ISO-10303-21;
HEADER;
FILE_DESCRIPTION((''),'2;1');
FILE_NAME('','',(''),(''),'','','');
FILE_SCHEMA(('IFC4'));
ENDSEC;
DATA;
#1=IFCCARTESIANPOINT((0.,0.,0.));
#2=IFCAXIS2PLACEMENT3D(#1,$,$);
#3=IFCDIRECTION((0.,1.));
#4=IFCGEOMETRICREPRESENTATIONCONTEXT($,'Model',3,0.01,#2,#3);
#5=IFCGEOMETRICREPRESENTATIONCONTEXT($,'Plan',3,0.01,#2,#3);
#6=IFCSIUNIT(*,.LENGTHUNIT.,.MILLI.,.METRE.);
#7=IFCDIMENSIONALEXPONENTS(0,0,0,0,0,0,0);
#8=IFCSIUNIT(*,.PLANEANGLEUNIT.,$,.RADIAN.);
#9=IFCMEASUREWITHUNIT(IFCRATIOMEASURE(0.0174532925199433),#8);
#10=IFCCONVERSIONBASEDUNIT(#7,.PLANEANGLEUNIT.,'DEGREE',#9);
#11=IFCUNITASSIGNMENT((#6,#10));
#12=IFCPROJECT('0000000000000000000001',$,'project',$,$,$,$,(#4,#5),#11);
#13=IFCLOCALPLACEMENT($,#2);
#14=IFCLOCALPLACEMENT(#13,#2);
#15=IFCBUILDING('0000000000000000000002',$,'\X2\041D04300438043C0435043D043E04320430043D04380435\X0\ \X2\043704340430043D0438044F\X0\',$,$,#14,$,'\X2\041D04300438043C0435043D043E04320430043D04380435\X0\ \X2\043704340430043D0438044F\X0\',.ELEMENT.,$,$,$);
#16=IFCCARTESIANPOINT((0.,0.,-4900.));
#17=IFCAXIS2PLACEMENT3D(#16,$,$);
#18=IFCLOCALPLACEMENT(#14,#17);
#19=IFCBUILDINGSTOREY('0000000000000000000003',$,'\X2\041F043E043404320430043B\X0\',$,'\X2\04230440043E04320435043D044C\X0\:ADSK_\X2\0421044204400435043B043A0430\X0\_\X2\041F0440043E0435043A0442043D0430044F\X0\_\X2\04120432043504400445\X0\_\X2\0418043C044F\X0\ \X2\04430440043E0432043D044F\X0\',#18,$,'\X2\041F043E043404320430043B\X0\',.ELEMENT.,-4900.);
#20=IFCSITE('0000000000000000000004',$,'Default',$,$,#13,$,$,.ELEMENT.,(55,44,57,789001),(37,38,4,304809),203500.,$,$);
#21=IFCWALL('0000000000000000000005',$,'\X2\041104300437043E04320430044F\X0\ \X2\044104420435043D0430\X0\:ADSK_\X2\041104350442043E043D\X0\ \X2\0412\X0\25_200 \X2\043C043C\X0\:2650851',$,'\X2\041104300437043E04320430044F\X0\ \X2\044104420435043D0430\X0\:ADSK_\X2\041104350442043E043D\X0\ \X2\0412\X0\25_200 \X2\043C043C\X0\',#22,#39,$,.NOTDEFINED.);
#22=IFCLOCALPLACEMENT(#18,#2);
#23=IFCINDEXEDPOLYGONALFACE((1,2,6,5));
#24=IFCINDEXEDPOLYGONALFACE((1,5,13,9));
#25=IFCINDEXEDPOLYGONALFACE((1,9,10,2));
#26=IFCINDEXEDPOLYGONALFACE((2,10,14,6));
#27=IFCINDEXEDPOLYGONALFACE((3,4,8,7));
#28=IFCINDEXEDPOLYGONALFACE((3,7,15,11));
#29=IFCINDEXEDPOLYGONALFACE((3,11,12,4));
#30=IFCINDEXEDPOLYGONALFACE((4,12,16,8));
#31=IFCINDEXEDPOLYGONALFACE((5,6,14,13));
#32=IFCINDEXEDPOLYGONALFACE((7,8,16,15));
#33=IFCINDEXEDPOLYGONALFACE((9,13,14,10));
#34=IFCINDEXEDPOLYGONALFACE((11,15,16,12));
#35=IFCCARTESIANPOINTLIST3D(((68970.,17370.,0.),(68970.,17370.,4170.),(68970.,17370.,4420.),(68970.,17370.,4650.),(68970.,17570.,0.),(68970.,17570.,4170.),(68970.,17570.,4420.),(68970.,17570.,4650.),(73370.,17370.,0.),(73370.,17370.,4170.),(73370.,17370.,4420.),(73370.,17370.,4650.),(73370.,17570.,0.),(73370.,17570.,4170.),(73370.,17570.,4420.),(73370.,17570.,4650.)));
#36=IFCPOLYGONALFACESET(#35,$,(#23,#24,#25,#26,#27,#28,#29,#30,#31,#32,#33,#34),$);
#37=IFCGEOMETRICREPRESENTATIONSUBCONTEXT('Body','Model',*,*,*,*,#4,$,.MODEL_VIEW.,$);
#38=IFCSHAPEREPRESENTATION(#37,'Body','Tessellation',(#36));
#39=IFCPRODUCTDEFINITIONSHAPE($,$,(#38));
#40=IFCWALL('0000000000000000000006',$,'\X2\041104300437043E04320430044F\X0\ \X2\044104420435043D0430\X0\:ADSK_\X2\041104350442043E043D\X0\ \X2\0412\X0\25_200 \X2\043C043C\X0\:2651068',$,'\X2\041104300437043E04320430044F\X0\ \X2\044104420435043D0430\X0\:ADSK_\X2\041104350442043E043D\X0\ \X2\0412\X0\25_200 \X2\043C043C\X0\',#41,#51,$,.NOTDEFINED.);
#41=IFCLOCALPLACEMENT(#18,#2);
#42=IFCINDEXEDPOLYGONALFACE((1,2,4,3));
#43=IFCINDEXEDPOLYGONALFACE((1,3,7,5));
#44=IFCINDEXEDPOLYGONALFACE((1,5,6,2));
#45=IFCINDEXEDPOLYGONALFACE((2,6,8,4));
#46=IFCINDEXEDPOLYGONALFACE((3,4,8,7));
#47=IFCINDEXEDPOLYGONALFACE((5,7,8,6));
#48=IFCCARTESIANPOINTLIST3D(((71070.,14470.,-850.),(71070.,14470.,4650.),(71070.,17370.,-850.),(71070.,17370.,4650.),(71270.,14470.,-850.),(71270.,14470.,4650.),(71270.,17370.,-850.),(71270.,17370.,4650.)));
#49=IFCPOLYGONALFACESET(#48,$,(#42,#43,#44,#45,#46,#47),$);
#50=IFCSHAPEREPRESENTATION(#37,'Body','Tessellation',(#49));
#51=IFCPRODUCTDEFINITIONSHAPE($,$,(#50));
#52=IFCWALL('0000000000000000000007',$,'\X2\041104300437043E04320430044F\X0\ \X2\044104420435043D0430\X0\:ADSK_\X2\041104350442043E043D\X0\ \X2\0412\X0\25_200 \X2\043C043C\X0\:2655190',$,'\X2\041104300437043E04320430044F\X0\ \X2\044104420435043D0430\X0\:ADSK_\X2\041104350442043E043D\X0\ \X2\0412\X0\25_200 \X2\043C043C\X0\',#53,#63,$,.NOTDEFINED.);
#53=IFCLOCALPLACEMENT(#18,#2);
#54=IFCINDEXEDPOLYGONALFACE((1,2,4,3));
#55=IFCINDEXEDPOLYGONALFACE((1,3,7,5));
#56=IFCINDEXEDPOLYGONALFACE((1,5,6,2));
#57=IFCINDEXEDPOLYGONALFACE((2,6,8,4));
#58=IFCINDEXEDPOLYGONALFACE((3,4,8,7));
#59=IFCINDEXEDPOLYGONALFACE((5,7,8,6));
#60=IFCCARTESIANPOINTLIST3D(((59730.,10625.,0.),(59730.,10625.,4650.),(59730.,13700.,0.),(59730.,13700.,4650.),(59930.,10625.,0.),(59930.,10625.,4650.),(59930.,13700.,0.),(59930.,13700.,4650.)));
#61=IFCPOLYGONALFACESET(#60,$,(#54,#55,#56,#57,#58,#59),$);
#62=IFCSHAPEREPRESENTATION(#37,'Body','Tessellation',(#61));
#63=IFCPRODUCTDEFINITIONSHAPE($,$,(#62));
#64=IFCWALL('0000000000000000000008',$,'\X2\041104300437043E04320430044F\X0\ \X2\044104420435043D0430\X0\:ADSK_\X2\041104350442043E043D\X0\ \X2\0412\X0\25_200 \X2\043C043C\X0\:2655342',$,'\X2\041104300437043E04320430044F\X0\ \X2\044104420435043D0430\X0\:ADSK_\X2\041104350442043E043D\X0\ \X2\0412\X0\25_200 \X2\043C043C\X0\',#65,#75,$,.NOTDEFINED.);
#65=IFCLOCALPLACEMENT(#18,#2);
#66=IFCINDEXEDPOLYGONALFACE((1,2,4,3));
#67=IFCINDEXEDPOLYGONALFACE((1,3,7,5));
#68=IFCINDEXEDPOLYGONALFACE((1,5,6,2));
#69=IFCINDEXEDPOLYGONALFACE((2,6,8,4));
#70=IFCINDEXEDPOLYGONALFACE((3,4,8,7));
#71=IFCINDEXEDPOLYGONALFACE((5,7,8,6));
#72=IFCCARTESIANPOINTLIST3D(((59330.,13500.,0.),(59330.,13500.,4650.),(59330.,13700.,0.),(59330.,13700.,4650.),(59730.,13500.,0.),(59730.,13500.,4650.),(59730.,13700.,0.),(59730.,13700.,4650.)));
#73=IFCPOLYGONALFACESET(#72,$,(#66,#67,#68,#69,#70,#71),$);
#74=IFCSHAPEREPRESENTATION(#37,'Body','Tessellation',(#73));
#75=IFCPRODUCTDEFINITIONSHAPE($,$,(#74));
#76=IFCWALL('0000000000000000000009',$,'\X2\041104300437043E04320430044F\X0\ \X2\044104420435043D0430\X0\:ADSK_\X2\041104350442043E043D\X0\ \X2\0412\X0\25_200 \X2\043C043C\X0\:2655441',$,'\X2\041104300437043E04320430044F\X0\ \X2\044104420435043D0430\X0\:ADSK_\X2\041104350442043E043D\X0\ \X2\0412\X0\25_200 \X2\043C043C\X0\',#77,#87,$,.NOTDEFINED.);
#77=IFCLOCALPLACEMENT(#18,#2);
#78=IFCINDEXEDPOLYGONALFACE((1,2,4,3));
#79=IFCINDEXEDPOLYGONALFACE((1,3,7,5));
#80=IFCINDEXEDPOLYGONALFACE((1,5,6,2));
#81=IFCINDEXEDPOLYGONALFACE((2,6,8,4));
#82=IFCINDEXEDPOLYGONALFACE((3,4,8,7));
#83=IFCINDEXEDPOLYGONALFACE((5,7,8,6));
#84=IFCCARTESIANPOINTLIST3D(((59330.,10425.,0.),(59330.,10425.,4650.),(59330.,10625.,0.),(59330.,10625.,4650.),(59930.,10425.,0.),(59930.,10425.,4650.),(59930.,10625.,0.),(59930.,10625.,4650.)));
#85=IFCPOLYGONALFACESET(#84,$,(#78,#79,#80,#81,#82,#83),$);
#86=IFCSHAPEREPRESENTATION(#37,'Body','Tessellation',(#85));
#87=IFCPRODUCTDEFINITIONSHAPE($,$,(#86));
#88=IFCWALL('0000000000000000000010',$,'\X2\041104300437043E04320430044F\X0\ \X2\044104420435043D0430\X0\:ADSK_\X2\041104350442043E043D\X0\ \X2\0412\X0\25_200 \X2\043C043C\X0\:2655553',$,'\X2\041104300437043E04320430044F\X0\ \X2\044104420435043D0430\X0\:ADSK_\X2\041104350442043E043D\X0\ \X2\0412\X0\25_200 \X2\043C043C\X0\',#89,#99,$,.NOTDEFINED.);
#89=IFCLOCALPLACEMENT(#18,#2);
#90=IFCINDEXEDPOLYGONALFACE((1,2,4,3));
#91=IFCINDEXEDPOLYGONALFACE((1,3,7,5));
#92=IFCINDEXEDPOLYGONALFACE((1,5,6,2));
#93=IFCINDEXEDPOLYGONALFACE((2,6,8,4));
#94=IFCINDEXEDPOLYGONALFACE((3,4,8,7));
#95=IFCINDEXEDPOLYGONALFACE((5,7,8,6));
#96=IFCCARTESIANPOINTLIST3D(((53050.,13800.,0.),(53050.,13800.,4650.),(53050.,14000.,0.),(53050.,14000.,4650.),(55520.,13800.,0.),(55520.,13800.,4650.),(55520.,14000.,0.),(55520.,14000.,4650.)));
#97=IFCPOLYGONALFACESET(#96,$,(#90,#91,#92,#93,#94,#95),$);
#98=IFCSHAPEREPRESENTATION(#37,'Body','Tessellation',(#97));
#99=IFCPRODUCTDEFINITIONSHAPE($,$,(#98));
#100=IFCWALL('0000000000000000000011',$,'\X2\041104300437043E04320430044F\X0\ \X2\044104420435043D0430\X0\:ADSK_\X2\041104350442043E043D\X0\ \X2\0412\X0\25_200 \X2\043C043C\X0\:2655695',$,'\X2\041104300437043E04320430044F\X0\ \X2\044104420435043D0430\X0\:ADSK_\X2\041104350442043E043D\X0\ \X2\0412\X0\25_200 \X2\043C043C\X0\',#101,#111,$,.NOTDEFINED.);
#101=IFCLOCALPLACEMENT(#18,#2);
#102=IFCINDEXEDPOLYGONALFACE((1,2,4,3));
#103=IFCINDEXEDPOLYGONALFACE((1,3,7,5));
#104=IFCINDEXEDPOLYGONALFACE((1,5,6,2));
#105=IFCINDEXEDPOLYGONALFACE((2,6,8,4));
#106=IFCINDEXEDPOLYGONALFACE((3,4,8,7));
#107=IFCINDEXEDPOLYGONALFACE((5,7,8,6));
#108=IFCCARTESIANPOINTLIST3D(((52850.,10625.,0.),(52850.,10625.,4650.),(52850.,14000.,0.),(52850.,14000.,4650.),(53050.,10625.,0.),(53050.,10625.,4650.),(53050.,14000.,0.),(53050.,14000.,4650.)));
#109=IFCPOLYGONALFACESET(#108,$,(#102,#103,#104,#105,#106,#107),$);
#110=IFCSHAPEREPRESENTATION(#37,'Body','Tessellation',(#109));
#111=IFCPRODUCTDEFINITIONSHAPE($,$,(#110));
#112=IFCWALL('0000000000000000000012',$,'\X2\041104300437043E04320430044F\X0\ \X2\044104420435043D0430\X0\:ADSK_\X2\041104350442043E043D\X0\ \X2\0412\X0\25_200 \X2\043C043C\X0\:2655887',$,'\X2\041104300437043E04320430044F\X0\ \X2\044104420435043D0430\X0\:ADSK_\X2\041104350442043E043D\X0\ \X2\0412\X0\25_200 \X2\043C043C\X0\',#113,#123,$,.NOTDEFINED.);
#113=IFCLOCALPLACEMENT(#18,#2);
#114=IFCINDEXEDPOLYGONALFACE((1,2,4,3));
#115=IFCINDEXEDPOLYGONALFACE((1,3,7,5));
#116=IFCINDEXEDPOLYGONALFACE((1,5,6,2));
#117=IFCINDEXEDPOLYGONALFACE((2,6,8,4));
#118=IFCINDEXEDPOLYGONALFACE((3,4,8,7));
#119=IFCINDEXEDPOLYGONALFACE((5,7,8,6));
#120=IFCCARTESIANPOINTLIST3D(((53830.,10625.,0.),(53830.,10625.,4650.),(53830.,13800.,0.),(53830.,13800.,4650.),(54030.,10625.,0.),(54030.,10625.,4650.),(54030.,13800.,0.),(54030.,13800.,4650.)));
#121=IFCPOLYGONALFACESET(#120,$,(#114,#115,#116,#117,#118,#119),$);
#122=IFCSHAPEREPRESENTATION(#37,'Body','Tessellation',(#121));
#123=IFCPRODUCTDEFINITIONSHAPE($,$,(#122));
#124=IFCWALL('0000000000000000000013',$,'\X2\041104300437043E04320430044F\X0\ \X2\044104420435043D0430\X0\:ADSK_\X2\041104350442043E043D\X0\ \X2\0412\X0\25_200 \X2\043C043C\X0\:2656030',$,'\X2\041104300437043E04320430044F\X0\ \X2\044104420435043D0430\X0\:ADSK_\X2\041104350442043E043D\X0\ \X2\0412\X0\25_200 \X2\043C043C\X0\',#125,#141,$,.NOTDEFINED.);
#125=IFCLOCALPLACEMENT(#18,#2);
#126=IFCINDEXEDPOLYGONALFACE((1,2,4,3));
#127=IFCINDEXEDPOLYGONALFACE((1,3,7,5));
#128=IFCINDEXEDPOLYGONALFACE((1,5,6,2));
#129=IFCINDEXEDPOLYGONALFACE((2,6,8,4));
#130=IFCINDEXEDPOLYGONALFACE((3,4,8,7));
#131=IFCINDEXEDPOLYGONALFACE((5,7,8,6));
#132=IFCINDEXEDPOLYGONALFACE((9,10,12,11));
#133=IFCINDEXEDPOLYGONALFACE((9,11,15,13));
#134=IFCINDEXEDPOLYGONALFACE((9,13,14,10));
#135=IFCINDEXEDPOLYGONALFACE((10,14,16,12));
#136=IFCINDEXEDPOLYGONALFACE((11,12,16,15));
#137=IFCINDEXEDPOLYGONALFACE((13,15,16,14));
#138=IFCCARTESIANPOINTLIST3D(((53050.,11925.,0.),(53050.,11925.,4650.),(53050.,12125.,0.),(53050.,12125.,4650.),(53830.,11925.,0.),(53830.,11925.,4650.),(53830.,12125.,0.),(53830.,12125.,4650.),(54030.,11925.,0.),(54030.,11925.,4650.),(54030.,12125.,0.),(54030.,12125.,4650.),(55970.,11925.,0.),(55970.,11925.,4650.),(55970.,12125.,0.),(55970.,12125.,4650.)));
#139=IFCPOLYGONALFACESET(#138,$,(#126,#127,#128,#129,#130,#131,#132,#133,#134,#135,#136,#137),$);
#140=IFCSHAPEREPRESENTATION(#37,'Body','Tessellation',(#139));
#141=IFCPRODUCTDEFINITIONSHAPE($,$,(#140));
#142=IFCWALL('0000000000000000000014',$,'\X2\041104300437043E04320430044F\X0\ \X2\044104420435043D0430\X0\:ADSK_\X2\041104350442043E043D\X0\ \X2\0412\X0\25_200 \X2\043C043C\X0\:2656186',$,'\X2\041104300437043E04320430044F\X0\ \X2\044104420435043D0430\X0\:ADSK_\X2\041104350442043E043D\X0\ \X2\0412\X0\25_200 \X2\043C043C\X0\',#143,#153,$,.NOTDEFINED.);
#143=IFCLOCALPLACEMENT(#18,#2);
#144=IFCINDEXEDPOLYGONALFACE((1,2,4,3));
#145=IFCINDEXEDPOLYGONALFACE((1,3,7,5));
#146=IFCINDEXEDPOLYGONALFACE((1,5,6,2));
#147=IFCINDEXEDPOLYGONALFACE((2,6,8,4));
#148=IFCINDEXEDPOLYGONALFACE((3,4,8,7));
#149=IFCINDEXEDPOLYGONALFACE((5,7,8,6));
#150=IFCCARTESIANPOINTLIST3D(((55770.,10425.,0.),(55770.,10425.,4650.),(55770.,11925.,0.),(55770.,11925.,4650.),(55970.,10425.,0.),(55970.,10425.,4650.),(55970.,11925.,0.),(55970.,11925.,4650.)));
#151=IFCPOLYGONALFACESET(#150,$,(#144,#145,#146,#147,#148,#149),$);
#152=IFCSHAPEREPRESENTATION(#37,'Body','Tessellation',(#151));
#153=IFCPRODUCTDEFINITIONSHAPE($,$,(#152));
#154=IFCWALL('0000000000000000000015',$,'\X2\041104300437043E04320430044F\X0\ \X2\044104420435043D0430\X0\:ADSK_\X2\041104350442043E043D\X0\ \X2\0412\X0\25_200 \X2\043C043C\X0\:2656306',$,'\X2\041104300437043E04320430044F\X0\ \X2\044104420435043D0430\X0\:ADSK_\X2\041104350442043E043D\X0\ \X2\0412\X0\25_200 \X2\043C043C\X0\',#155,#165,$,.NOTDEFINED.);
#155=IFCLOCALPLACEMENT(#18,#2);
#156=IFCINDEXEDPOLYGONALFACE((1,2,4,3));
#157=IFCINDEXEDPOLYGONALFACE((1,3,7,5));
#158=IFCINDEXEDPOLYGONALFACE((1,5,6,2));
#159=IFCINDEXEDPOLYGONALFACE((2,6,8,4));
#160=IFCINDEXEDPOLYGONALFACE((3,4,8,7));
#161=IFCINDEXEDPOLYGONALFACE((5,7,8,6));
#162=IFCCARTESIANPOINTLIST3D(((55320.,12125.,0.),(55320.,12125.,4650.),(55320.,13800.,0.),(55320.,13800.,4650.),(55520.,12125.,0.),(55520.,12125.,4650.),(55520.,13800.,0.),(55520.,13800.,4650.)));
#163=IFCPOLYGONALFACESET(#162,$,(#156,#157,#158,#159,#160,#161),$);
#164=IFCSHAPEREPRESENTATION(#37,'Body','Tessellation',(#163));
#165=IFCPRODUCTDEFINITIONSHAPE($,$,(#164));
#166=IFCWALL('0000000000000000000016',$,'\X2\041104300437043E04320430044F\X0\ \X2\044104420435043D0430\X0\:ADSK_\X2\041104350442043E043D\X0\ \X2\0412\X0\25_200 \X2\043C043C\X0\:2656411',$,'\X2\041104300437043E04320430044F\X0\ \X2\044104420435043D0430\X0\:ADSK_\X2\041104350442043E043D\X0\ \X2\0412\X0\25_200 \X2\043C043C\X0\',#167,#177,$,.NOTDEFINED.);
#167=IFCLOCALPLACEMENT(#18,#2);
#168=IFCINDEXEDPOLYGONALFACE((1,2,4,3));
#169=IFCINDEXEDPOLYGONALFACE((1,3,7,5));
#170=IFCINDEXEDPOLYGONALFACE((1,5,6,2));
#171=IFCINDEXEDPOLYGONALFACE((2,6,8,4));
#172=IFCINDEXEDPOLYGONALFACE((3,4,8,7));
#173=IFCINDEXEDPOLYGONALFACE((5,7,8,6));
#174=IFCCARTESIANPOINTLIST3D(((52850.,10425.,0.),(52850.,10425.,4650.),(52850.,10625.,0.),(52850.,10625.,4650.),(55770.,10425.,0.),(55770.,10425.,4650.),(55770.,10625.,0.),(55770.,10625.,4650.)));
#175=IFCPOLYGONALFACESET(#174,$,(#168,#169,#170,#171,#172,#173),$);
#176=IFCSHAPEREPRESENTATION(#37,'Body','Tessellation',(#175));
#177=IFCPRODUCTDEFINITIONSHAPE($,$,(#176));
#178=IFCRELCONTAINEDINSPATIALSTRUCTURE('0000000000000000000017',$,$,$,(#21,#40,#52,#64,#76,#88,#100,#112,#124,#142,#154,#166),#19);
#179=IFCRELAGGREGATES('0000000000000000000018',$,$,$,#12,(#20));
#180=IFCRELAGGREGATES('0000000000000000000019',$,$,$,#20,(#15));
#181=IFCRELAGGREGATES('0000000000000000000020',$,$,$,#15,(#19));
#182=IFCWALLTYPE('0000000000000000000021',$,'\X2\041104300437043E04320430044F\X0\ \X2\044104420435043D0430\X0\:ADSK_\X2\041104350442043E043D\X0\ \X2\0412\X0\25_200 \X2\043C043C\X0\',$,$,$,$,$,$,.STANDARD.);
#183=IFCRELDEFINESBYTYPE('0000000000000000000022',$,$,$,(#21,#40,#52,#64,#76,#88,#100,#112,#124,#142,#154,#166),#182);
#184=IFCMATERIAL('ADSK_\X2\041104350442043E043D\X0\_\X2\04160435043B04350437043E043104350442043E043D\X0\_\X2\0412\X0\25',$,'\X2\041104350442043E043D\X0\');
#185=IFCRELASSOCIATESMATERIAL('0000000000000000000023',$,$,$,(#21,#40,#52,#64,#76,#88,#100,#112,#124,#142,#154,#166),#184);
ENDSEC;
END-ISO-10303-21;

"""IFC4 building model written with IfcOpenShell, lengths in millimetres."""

from ifc_helpers import new_model, entity, si_unit, converted_unit, direction, frame, origin, place, context, subcontext, project, spatial, indexed_curve, outline, extrude, material, type_object, element, save


model = new_model("IFC4")

# Units and contexts
model_context = context("Model", 3, precision=0.01, world=origin(), true_north=direction((0.0, 1.0)))
plan_context = context("Plan", 3, precision=0.01, world=origin(), true_north=direction((0.0, 1.0)))
body_context = subcontext(model_context, "Body", "Model", "MODEL_VIEW")
ifc_project = project(units=[si_unit("LENGTHUNIT", "METRE", prefix="MILLI"), converted_unit("PLANEANGLEUNIT", "DEGREE", entity("IfcRatioMeasure", 0.0174532925199433), si_unit("PLANEANGLEUNIT", "RADIAN"), dimensions=[0, 0, 0, 0, 0, 0, 0])], contexts=[model_context, plan_context])

# Site, building, storey
site_placement = place(None, origin())
site = spatial("IfcSite", under=ifc_project, at=site_placement, Name="Default", CompositionType="ELEMENT", RefLatitude=(55, 44, 57, 789001), RefLongitude=(37, 38, 4, 304809), RefElevation=203500.0)
building_placement = place(site_placement, origin())
building = spatial("IfcBuilding", under=site, at=building_placement, Name="Наименование здания", LongName="Наименование здания", CompositionType="ELEMENT")
storey_placement = place(building_placement, frame((0.0, 0.0, -4900.0)))
storey = spatial("IfcBuildingStorey", under=building, at=storey_placement, Name="Подвал", ObjectType="Уровень:ADSK_Стрелка_Проектная_Вверх_Имя уровня", LongName="Подвал", CompositionType="ELEMENT", Elevation=-4900.0)

# Wall, opening
ifc_material = material(Name="ADSK_Бетон_Железобетон_В25", Category="Бетон")
wall_type_1 = type_object("IfcWallType", Name="Базовая стена:ADSK_Бетон В25_200 мм", PredefinedType="STANDARD")
wall_1_placement = place(storey_placement, frame((73370.0, 17470.0, 0.0), z_axis=(0.0, 0.0, 1.0), x_axis=(-1.0, 0.0, 0.0)))
wall_1 = element("IfcWall", 1, at=wall_1_placement, inside=storey, type_object=wall_type_1, material=ifc_material, Name="Базовая стена:ADSK_Бетон В25_200 мм:2650851", ObjectType="Базовая стена:ADSK_Бетон В25_200 мм", PredefinedType="NOTDEFINED", context=body_context, shape_type="SweptSolid", body=[
    extrude(outline(indexed_curve([(4400.0, 100.0), (0.0, 100.0), (0.0, -100.0), (4400.0, -100.0), (4400.0, 100.0)], self_intersect=False)), origin(), (0.0, 0.0, 1.0), 4650.0),
])
opening_1_placement = place(storey_placement, frame((73370.0, 17470.0, 0.0), z_axis=(0.0, 0.0, 1.0), x_axis=(-1.0, 0.0, 0.0)))
element("IfcOpeningElement", 2, at=opening_1_placement, cuts=wall_1, PredefinedType="OPENING", context=body_context, shape_type="SweptSolid", body=[
    extrude(outline(indexed_curve([(-2200.0, -100.0), (2200.0, -100.0), (2200.0, 100.0), (-2200.0, 100.0), (-2200.0, -100.0)], self_intersect=False)), frame((2200.0, 0.0, 4170.0)), (0.0, 0.0, 1.0), 250.0),
])

# Walls
wall_2_placement = place(storey_placement, frame((71170.0, 14470.0, -850.0), z_axis=(0.0, 0.0, 1.0), x_axis=(0.0, 1.0, 0.0)))
element("IfcWall", 3, at=wall_2_placement, inside=storey, type_object=wall_type_1, material=ifc_material, Name="Базовая стена:ADSK_Бетон В25_200 мм:2651068", ObjectType="Базовая стена:ADSK_Бетон В25_200 мм", PredefinedType="NOTDEFINED", context=body_context, shape_type="SweptSolid", body=[
    extrude(outline(indexed_curve([(2900.0, 100.0), (0.0, 100.0), (0.0, -100.0), (2900.0, -100.0), (2900.0, 100.0)], self_intersect=False)), origin(), (0.0, 0.0, 1.0), 5500.0),
])
wall_3_placement = place(storey_placement, frame((59830.0, 10625.0, 0.0), z_axis=(0.0, 0.0, 1.0), x_axis=(0.0, 1.0, 0.0)))
element("IfcWall", 4, at=wall_3_placement, inside=storey, type_object=wall_type_1, material=ifc_material, Name="Базовая стена:ADSK_Бетон В25_200 мм:2655190", ObjectType="Базовая стена:ADSK_Бетон В25_200 мм", PredefinedType="NOTDEFINED", context=body_context, shape_type="SweptSolid", body=[
    extrude(outline(indexed_curve([(3075.0, 100.0), (0.0, 100.0), (0.0, -100.0), (3075.0, -100.0), (3075.0, 100.0)], self_intersect=False)), origin(), (0.0, 0.0, 1.0), 4650.0),
])
wall_4_placement = place(storey_placement, frame((59730.0, 13600.0, 0.0), z_axis=(0.0, 0.0, 1.0), x_axis=(-1.0, 0.0, 0.0)))
element("IfcWall", 5, at=wall_4_placement, inside=storey, type_object=wall_type_1, material=ifc_material, Name="Базовая стена:ADSK_Бетон В25_200 мм:2655342", ObjectType="Базовая стена:ADSK_Бетон В25_200 мм", PredefinedType="NOTDEFINED", context=body_context, shape_type="SweptSolid", body=[
    extrude(outline(indexed_curve([(400.0, 100.0), (0.0, 100.0), (0.0, -100.0), (400.0, -100.0), (400.0, 100.0)], self_intersect=False)), origin(), (0.0, 0.0, 1.0), 4650.0),
])
wall_5_placement = place(storey_placement, frame((59930.0, 10525.0, 0.0), z_axis=(0.0, 0.0, 1.0), x_axis=(-1.0, 0.0, 0.0)))
element("IfcWall", 6, at=wall_5_placement, inside=storey, type_object=wall_type_1, material=ifc_material, Name="Базовая стена:ADSK_Бетон В25_200 мм:2655441", ObjectType="Базовая стена:ADSK_Бетон В25_200 мм", PredefinedType="NOTDEFINED", context=body_context, shape_type="SweptSolid", body=[
    extrude(outline(indexed_curve([(600.0, 100.0), (0.0, 100.0), (0.0, -100.0), (600.0, -100.0), (600.0, 100.0)], self_intersect=False)), origin(), (0.0, 0.0, 1.0), 4650.0),
])
wall_6_placement = place(storey_placement, frame((55520.0, 13900.0, 0.0), z_axis=(0.0, 0.0, 1.0), x_axis=(-1.0, 0.0, 0.0)))
element("IfcWall", 7, at=wall_6_placement, inside=storey, type_object=wall_type_1, material=ifc_material, Name="Базовая стена:ADSK_Бетон В25_200 мм:2655553", ObjectType="Базовая стена:ADSK_Бетон В25_200 мм", PredefinedType="NOTDEFINED", context=body_context, shape_type="SweptSolid", body=[
    extrude(outline(indexed_curve([(2470.0, 100.0), (0.0, 100.0), (0.0, -100.0), (2470.0, -100.0), (2470.0, 100.0)], self_intersect=False)), origin(), (0.0, 0.0, 1.0), 4650.0),
])
wall_7_placement = place(storey_placement, frame((52950.0, 14000.0, 0.0), z_axis=(0.0, 0.0, 1.0), x_axis=(0.0, -1.0, 0.0)))
element("IfcWall", 8, at=wall_7_placement, inside=storey, type_object=wall_type_1, material=ifc_material, Name="Базовая стена:ADSK_Бетон В25_200 мм:2655695", ObjectType="Базовая стена:ADSK_Бетон В25_200 мм", PredefinedType="NOTDEFINED", context=body_context, shape_type="SweptSolid", body=[
    extrude(outline(indexed_curve([(3375.0, 100.0), (0.0, 100.0), (0.0, -100.0), (3375.0, -100.0), (3375.0, 100.0)], self_intersect=False)), origin(), (0.0, 0.0, 1.0), 4650.0),
])
wall_8_placement = place(storey_placement, frame((53930.0, 13800.0, 0.0), z_axis=(0.0, 0.0, 1.0), x_axis=(0.0, -1.0, 0.0)))
element("IfcWall", 9, at=wall_8_placement, inside=storey, type_object=wall_type_1, material=ifc_material, Name="Базовая стена:ADSK_Бетон В25_200 мм:2655887", ObjectType="Базовая стена:ADSK_Бетон В25_200 мм", PredefinedType="NOTDEFINED", context=body_context, shape_type="SweptSolid", body=[
    extrude(outline(indexed_curve([(3175.0, 100.0), (0.0, 100.0), (0.0, -100.0), (3175.0, -100.0), (3175.0, 100.0)], self_intersect=False)), origin(), (0.0, 0.0, 1.0), 4650.0),
])

# Wall, opening
wall_9_placement = place(storey_placement, frame((53050.0, 12025.0, 0.0)))
wall_9 = element("IfcWall", 10, at=wall_9_placement, inside=storey, type_object=wall_type_1, material=ifc_material, Name="Базовая стена:ADSK_Бетон В25_200 мм:2656030", ObjectType="Базовая стена:ADSK_Бетон В25_200 мм", PredefinedType="NOTDEFINED", context=body_context, shape_type="SweptSolid", body=[
    extrude(outline(indexed_curve([(2920.0, 100.0), (0.0, 100.0), (0.0, -100.0), (2920.0, -100.0), (2920.0, 100.0)], self_intersect=False)), origin(), (0.0, 0.0, 1.0), 4650.0),
])
opening_2_placement = place(storey_placement, frame((53050.0, 12025.0, 0.0)))
element("IfcOpeningElement", 11, at=opening_2_placement, cuts=wall_9, PredefinedType="OPENING", context=body_context, shape_type="SweptSolid", body=[
    extrude(outline(indexed_curve([(-2325.0, -100.0), (2325.0, -100.0), (2325.0, 100.0), (-2325.0, 100.0), (-2325.0, -100.0)], self_intersect=False)), frame((780.0, 0.0, 2325.0), z_axis=(1.0, 0.0, 0.0), x_axis=(0.0, 0.0, -1.0)), (0.0, 0.0, 1.0), 200.0),
])

# Walls
wall_10_placement = place(storey_placement, frame((55870.0, 11925.0, 0.0), z_axis=(0.0, 0.0, 1.0), x_axis=(0.0, -1.0, 0.0)))
element("IfcWall", 12, at=wall_10_placement, inside=storey, type_object=wall_type_1, material=ifc_material, Name="Базовая стена:ADSK_Бетон В25_200 мм:2656186", ObjectType="Базовая стена:ADSK_Бетон В25_200 мм", PredefinedType="NOTDEFINED", context=body_context, shape_type="SweptSolid", body=[
    extrude(outline(indexed_curve([(1500.0, 100.0), (0.0, 100.0), (0.0, -100.0), (1500.0, -100.0), (1500.0, 100.0)], self_intersect=False)), origin(), (0.0, 0.0, 1.0), 4650.0),
])
wall_11_placement = place(storey_placement, frame((55420.0, 13800.0, 0.0), z_axis=(0.0, 0.0, 1.0), x_axis=(0.0, -1.0, 0.0)))
element("IfcWall", 13, at=wall_11_placement, inside=storey, type_object=wall_type_1, material=ifc_material, Name="Базовая стена:ADSK_Бетон В25_200 мм:2656306", ObjectType="Базовая стена:ADSK_Бетон В25_200 мм", PredefinedType="NOTDEFINED", context=body_context, shape_type="SweptSolid", body=[
    extrude(outline(indexed_curve([(1675.0, 100.0), (0.0, 100.0), (0.0, -100.0), (1675.0, -100.0), (1675.0, 100.0)], self_intersect=False)), origin(), (0.0, 0.0, 1.0), 4650.0),
])
wall_12_placement = place(storey_placement, frame((55770.0, 10525.0, 0.0), z_axis=(0.0, 0.0, 1.0), x_axis=(-1.0, 0.0, 0.0)))
element("IfcWall", 14, at=wall_12_placement, inside=storey, type_object=wall_type_1, material=ifc_material, Name="Базовая стена:ADSK_Бетон В25_200 мм:2656411", ObjectType="Базовая стена:ADSK_Бетон В25_200 мм", PredefinedType="NOTDEFINED", context=body_context, shape_type="SweptSolid", body=[
    extrude(outline(indexed_curve([(2920.0, 100.0), (0.0, 100.0), (0.0, -100.0), (2920.0, -100.0), (2920.0, 100.0)], self_intersect=False)), origin(), (0.0, 0.0, 1.0), 4650.0),
])

save(model, "model.ifc")
